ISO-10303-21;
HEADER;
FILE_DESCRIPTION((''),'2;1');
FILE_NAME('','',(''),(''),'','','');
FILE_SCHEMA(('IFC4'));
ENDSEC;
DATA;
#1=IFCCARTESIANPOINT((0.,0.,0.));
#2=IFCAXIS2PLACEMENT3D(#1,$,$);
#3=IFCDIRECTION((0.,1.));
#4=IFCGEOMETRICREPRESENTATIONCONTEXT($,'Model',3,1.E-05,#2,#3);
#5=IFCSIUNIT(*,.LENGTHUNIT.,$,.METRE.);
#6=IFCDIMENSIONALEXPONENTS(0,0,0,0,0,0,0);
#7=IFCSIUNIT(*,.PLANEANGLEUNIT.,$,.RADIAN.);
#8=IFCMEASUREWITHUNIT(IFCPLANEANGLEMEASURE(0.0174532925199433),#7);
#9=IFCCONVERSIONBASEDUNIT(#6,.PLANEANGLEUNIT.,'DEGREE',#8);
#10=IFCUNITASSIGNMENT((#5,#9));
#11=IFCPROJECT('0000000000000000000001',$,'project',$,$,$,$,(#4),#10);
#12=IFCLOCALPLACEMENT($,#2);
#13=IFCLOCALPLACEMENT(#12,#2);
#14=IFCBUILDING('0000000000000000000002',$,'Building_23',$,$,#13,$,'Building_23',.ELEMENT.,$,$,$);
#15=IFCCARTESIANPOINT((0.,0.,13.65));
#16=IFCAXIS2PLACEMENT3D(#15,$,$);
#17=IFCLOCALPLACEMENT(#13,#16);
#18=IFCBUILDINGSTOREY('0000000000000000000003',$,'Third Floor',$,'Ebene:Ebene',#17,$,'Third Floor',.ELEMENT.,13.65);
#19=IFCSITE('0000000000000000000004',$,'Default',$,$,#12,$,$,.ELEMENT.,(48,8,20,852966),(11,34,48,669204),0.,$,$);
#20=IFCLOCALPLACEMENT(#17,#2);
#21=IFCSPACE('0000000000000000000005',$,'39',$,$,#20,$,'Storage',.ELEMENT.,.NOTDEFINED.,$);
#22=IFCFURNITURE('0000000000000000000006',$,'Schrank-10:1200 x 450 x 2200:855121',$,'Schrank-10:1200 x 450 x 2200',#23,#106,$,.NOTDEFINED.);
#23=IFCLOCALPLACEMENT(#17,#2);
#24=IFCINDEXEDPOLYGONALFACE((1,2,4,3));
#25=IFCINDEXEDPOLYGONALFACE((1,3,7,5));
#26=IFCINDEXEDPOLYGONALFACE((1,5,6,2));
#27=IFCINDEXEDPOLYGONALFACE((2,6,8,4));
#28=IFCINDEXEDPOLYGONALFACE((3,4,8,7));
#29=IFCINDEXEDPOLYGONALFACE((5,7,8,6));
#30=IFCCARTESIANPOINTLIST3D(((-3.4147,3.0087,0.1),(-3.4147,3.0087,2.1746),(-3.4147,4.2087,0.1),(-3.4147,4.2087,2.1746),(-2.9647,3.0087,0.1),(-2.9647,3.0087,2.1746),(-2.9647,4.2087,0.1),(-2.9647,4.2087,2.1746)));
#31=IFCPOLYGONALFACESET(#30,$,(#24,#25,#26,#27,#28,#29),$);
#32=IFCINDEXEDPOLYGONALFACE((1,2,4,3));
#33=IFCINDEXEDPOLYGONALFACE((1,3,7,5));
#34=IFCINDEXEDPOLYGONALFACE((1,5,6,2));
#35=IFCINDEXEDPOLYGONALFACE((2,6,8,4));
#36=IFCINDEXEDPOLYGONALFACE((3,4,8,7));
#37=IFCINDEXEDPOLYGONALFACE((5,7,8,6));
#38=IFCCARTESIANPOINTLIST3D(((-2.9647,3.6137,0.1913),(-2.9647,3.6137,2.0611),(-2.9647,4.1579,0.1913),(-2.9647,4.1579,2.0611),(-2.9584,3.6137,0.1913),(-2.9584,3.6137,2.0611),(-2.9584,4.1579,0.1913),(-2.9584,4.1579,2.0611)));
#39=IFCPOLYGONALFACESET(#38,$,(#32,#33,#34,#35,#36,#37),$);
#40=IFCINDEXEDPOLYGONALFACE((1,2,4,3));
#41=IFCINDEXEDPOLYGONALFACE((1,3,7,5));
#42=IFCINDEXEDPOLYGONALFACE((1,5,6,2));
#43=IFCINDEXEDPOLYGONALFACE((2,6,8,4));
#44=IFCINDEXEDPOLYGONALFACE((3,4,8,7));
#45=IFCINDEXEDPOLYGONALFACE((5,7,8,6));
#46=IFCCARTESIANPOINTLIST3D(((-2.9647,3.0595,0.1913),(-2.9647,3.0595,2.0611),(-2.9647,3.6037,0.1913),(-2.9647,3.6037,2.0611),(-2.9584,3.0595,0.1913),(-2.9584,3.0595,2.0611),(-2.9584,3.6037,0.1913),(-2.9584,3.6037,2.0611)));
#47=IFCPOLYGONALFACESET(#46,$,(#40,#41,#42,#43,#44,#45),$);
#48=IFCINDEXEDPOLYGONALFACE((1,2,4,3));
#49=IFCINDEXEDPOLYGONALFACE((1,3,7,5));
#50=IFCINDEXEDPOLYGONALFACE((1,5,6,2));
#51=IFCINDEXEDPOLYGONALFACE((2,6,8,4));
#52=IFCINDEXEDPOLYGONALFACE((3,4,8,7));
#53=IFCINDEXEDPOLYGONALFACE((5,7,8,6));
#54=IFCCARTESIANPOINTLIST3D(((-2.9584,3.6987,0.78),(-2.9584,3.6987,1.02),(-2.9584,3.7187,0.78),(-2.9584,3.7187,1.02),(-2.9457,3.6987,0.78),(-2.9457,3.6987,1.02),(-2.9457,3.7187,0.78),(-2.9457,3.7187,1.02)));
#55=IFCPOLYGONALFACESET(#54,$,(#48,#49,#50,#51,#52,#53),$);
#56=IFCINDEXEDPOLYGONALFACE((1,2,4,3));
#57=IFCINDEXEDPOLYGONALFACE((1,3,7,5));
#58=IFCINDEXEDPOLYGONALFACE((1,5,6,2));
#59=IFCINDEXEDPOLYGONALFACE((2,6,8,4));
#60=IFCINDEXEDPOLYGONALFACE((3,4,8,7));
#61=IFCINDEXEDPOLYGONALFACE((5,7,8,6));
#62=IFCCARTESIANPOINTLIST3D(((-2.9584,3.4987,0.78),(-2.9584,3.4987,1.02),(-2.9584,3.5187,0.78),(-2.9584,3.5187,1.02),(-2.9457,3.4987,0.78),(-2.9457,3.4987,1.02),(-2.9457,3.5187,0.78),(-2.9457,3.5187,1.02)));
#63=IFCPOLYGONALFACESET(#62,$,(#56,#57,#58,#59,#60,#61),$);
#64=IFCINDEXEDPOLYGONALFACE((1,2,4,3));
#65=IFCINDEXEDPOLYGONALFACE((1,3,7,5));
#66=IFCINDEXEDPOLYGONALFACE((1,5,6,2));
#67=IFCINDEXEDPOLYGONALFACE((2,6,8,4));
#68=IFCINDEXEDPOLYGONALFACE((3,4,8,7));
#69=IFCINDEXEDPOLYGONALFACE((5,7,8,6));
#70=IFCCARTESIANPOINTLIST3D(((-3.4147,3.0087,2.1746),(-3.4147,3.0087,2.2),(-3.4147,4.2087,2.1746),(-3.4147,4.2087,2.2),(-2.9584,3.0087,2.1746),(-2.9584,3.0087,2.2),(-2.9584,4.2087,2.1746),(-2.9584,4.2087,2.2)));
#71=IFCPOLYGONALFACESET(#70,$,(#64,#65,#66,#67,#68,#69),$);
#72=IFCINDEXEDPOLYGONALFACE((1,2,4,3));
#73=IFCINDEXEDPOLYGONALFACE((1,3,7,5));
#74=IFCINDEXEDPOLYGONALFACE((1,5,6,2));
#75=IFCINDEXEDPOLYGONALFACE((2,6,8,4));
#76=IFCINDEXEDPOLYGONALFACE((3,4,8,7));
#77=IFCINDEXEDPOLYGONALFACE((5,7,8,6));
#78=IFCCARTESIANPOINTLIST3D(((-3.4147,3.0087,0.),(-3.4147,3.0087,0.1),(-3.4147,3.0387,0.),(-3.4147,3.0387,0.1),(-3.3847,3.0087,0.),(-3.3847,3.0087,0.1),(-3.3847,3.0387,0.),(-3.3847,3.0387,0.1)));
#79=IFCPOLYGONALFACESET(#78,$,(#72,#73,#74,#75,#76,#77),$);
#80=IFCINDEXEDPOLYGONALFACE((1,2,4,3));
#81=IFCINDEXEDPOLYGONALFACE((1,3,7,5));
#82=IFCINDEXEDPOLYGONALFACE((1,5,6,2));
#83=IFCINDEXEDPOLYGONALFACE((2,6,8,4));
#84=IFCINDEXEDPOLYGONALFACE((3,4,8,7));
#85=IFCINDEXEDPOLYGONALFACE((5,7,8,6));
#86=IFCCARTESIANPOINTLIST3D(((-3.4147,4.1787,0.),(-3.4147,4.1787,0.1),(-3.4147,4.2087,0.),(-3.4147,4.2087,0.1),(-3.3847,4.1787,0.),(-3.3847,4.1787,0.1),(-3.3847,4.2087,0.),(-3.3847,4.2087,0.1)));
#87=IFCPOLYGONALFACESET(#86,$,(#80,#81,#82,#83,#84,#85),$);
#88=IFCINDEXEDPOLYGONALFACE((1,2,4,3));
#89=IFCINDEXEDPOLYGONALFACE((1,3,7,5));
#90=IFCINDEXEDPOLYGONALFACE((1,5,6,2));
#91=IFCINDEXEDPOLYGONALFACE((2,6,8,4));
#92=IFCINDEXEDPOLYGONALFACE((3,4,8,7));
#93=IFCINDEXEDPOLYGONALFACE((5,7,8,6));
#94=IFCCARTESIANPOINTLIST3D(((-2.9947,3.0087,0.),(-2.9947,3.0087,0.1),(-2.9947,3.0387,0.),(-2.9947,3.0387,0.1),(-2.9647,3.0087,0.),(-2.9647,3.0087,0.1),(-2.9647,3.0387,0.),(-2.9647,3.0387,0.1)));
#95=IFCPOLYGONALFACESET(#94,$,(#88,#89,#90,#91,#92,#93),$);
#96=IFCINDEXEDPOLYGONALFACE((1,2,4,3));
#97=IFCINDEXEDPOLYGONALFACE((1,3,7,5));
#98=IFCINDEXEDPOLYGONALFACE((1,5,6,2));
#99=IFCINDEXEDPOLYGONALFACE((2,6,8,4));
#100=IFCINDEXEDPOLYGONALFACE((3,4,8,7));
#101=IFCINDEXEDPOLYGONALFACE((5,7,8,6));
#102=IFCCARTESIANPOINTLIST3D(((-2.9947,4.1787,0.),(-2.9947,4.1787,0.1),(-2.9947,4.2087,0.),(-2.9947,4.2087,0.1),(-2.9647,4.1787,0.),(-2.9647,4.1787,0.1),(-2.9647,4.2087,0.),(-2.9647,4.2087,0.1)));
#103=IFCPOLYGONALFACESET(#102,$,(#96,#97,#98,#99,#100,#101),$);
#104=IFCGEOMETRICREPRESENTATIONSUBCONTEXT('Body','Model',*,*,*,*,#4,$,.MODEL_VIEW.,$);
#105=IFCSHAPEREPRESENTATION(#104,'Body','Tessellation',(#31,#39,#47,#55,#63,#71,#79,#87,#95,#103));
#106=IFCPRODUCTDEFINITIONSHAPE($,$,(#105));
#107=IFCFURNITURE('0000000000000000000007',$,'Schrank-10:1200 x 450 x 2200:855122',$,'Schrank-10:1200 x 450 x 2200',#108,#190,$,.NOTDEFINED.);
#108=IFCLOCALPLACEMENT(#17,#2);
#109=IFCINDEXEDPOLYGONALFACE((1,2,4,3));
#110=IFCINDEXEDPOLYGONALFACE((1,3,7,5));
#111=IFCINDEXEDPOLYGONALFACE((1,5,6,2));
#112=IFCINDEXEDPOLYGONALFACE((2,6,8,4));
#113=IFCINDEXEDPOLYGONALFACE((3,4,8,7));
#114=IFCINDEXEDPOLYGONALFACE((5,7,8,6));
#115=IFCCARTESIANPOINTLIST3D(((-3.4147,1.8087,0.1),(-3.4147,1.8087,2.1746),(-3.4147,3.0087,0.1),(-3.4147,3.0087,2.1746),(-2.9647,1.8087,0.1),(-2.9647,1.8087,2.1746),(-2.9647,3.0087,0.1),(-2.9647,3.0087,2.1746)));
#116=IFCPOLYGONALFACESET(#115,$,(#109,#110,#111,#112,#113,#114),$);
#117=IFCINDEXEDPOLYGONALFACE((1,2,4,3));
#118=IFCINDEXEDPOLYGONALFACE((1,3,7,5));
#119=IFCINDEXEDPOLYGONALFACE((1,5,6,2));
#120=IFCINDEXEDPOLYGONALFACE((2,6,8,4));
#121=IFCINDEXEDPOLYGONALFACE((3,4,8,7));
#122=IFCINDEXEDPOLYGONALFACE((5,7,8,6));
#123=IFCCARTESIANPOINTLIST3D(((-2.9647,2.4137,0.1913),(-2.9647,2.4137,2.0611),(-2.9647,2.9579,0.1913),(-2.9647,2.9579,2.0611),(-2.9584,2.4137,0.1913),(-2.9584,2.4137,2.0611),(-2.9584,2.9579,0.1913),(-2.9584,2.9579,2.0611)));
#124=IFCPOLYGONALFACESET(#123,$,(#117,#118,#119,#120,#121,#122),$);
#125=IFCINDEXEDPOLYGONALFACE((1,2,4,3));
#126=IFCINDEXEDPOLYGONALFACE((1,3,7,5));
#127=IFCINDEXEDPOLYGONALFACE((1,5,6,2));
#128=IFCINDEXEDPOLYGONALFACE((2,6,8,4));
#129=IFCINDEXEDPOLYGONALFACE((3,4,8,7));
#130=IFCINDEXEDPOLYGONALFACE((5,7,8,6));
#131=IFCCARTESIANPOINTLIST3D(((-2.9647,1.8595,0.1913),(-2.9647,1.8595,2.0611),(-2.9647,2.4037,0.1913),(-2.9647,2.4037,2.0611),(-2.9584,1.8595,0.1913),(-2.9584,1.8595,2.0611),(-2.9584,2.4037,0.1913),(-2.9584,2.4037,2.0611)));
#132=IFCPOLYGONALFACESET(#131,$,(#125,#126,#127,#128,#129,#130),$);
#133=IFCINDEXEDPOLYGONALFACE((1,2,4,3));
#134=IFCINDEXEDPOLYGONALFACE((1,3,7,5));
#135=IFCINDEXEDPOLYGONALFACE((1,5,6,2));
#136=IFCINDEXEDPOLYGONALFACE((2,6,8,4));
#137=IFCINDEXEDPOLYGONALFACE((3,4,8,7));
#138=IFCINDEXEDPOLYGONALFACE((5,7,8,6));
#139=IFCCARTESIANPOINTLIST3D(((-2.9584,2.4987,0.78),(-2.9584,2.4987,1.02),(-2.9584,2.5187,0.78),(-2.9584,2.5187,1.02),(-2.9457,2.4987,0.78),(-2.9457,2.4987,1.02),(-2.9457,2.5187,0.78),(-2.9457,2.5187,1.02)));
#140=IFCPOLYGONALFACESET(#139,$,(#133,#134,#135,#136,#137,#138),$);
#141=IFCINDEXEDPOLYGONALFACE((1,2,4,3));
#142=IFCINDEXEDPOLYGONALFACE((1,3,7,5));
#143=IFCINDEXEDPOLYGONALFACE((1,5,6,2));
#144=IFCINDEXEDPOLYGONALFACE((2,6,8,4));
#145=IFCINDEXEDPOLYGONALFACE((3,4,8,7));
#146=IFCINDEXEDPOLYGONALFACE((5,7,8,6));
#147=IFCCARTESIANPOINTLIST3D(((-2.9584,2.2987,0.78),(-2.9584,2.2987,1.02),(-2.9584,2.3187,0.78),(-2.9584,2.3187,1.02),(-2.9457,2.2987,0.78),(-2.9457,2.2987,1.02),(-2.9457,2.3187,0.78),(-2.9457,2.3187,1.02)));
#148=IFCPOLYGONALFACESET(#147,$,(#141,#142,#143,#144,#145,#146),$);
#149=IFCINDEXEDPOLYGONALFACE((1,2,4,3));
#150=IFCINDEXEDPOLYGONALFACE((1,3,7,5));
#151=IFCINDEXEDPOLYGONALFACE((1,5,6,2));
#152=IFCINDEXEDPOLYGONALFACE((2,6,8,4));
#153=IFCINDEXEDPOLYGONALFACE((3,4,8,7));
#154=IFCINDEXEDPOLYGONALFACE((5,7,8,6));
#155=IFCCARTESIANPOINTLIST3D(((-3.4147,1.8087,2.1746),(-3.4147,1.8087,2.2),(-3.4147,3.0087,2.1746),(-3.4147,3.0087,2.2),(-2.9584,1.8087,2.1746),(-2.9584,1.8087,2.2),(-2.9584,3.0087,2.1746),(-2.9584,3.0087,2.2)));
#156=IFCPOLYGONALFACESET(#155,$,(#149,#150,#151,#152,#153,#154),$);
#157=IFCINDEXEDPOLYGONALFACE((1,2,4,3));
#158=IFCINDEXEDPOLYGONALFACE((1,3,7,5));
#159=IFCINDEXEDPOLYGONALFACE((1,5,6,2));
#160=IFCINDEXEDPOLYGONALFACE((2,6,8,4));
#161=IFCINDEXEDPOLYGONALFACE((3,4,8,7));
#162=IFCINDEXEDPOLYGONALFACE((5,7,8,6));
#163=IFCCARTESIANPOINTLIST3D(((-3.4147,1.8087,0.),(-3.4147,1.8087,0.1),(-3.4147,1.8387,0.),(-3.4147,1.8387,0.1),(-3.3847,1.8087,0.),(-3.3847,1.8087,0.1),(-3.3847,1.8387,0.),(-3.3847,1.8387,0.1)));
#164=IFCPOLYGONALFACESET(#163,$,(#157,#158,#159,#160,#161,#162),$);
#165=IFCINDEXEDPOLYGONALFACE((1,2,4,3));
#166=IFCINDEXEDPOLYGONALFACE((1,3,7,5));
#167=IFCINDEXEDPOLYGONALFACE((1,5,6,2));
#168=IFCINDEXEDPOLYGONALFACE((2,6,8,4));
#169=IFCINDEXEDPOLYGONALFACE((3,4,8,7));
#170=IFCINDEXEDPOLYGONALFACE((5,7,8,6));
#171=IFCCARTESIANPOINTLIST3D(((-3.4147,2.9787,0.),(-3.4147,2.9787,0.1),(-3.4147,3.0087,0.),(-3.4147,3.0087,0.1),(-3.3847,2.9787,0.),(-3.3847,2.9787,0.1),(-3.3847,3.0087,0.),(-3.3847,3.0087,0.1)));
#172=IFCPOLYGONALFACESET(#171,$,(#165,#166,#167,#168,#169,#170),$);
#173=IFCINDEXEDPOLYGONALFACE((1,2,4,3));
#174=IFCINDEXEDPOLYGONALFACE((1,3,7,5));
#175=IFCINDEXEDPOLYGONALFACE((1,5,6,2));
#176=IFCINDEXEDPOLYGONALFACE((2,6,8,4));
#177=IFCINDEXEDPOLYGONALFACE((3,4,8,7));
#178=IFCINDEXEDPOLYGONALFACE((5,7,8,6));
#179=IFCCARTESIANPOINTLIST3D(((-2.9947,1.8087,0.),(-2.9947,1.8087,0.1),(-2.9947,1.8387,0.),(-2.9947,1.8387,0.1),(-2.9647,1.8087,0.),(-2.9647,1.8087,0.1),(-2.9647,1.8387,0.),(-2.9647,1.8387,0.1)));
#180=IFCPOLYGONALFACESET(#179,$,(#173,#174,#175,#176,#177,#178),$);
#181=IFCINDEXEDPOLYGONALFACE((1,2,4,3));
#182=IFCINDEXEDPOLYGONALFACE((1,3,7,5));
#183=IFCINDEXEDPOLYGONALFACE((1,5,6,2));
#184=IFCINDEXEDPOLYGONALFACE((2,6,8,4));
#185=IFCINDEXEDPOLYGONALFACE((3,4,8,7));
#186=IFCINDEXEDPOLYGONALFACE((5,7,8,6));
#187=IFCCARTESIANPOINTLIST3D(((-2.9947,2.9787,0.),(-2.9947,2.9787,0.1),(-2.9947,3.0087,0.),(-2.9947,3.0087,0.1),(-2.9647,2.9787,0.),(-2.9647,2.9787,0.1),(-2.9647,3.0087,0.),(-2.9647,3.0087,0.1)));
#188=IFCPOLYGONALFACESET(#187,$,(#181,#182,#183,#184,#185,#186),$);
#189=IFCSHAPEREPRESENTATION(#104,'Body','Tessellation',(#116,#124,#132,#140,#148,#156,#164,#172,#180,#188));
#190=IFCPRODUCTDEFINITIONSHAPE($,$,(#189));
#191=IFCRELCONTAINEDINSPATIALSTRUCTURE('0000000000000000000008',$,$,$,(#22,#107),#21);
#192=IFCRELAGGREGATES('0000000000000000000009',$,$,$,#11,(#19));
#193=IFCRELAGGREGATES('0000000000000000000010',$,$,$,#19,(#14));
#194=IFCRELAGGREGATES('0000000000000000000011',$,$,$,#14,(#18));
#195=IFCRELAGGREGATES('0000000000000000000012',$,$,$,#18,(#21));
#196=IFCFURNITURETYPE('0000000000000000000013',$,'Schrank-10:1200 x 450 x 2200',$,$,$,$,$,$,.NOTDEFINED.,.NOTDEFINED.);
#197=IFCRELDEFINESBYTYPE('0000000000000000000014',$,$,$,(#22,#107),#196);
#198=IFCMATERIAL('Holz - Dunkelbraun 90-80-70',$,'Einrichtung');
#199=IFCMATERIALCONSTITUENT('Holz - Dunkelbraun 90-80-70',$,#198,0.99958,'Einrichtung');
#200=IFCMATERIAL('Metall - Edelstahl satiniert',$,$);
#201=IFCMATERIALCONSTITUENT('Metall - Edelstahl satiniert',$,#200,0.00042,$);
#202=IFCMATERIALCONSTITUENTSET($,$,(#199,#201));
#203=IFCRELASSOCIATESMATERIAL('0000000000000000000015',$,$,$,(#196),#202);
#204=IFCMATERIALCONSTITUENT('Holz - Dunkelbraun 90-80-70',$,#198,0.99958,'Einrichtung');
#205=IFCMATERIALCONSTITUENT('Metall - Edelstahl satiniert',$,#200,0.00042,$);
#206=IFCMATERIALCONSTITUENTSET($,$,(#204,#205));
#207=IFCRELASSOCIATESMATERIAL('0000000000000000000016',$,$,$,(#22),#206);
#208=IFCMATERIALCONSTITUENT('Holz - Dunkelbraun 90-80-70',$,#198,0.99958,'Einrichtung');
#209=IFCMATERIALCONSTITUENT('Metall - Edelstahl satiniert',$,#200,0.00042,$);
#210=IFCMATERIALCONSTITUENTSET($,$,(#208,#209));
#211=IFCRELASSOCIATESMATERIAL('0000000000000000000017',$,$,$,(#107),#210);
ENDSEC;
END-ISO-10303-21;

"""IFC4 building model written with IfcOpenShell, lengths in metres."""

from ifc_helpers import new_model, entity, si_unit, converted_unit, direction, frame, origin, place, context, subcontext, project, spatial, indexed_curve, outline, extrude, source, transform, mapped, material, constituent, constituent_set, type_object, type_shapes, element, save


model = new_model("IFC4")

# Units and contexts
model_context = context("Model", 3, precision=1e-05, world=origin(), true_north=direction((0.0, 1.0)))
body_context = subcontext(model_context, "Body", "Model", "MODEL_VIEW")
ifc_project = project(units=[si_unit("LENGTHUNIT", "METRE"), converted_unit("PLANEANGLEUNIT", "DEGREE", entity("IfcPlaneAngleMeasure", 0.0174532925199433), si_unit("PLANEANGLEUNIT", "RADIAN"), dimensions=[0, 0, 0, 0, 0, 0, 0])], contexts=[model_context])

# Site, building, storey
site_placement = place(None, origin())
site = spatial("IfcSite", under=ifc_project, at=site_placement, Name="Default", CompositionType="ELEMENT", RefLatitude=(48, 8, 20, 852966), RefLongitude=(11, 34, 48, 669204), RefElevation=0.0)
building_placement = place(site_placement, origin())
building = spatial("IfcBuilding", under=site, at=building_placement, Name="Building_23", LongName="Building_23", CompositionType="ELEMENT")
storey_placement = place(building_placement, frame((0.0, 0.0, 13.65)))
storey = spatial("IfcBuildingStorey", under=building, at=storey_placement, Name="Third Floor", ObjectType="Ebene:Ebene", LongName="Third Floor", CompositionType="ELEMENT", Elevation=13.65)

# Shared definitions
ifc_material_1 = material(Name="Holz - Dunkelbraun 90-80-70", Category="Einrichtung")
ifc_material_2 = material(Name="Metall - Edelstahl satiniert")

# Shared definitions
space_1_placement = place(storey_placement, origin())
space_1 = spatial("IfcSpace", under=storey, at=space_1_placement, Name="39", LongName="Storage", CompositionType="ELEMENT", PredefinedType="NOTDEFINED")

# Furniture
ifc_constituent_1 = constituent(ifc_material_1, Name="Holz - Dunkelbraun 90-80-70", Category="Einrichtung", fraction=0.99958)
ifc_constituent_2 = constituent(ifc_material_2, Name="Metall - Edelstahl satiniert", fraction=0.00042)
ifc_constituent_set_1 = constituent_set(constituents=[ifc_constituent_1, ifc_constituent_2])
ifc_constituent_3 = constituent(ifc_material_1, Name="Holz - Dunkelbraun 90-80-70", Category="Einrichtung", fraction=0.99958)
ifc_constituent_4 = constituent(ifc_material_2, Name="Metall - Edelstahl satiniert", fraction=0.00042)
ifc_constituent_set_2 = constituent_set(constituents=[ifc_constituent_3, ifc_constituent_4])
furniture_type_1 = type_object("IfcFurnitureType", Name="Schrank-10:1200 x 450 x 2200", AssemblyPlace="NOTDEFINED", PredefinedType="NOTDEFINED", material=ifc_constituent_set_2)
shared_shape_1 = source(origin(), body_context, "Body", "SweptSolid", [
    extrude(outline(indexed_curve([(-0.225, -0.6), (0.225, -0.6), (0.225, 0.6), (-0.225, 0.6), (-0.225, -0.6)], self_intersect=False)), frame((-0.2692, -0.3632, 0.1), z_axis=(0.0, 0.0, 1.0), x_axis=(0.0, 1.0, 0.0)), (0.0, 0.0, 1.0), 2.0746),
    extrude(outline(indexed_curve([(-0.0032, -0.2721), (0.0032, -0.2721), (0.0032, 0.2721), (-0.0032, 0.2721), (-0.0032, -0.2721)], self_intersect=False)), frame((0.0079, -0.5913, 0.1913), z_axis=(0.0, 0.0, 1.0), x_axis=(0.0, 1.0, 0.0)), (0.0, 0.0, 1.0), 1.8698),
    extrude(outline(indexed_curve([(-0.0032, -0.2721), (0.0032, -0.2721), (0.0032, 0.2721), (-0.0032, 0.2721), (-0.0032, -0.2721)], self_intersect=False)), frame((-0.5463, -0.5913, 0.1913), z_axis=(0.0, 0.0, 1.0), x_axis=(0.0, 1.0, 0.0)), (0.0, 0.0, 1.0), 1.8698),
    extrude(outline(indexed_curve([(-0.0063, -0.01), (0.0063, -0.01), (0.0063, 0.01), (-0.0063, 0.01), (-0.0063, -0.01)], self_intersect=False)), frame((-0.1692, -0.6009, 0.78), z_axis=(0.0, 0.0, 1.0), x_axis=(0.0, 1.0, 0.0)), (0.0, 0.0, 1.0), 0.24),
    extrude(outline(indexed_curve([(-0.0063, -0.01), (0.0063, -0.01), (0.0063, 0.01), (-0.0063, 0.01), (-0.0063, -0.01)], self_intersect=False)), frame((-0.3692, -0.6009, 0.78), z_axis=(0.0, 0.0, 1.0), x_axis=(0.0, 1.0, 0.0)), (0.0, 0.0, 1.0), 0.24),
    extrude(outline(indexed_curve([(-0.6, -0.2282), (0.6, -0.2282), (0.6, 0.2282), (-0.6, 0.2282), (-0.6, -0.2282)], self_intersect=False)), frame((-0.2692, -0.3663, 2.1746), z_axis=(0.0, 0.0, 1.0), x_axis=(-1.0, 0.0, 0.0)), (0.0, 0.0, 1.0), 0.0254),
    extrude(outline(indexed_curve([(-0.015, -0.015), (0.015, -0.015), (0.015, 0.015), (-0.015, 0.015), (-0.015, -0.015)], self_intersect=False)), frame((-0.8542, -0.1532, 0.0), z_axis=(0.0, 0.0, 1.0), x_axis=(-1.0, 0.0, 0.0)), (0.0, 0.0, 1.0), 0.1),
    extrude(outline(indexed_curve([(-0.015, -0.015), (0.015, -0.015), (0.015, 0.015), (-0.015, 0.015), (-0.015, -0.015)], self_intersect=False)), frame((0.3158, -0.1532, 0.0), z_axis=(0.0, 0.0, 1.0), x_axis=(0.0, -1.0, 0.0)), (0.0, 0.0, 1.0), 0.1),
    extrude(outline(indexed_curve([(-0.015, -0.015), (0.015, -0.015), (0.015, 0.015), (-0.015, 0.015), (-0.015, -0.015)], self_intersect=False)), frame((-0.8542, -0.5732, 0.0), z_axis=(0.0, 0.0, 1.0), x_axis=(0.0, 1.0, 0.0)), (0.0, 0.0, 1.0), 0.1),
    extrude(outline(indexed_curve([(-0.015, -0.015), (0.015, -0.015), (0.015, 0.015), (-0.015, 0.015), (-0.015, -0.015)], self_intersect=False)), frame((0.3158, -0.5732, 0.0)), (0.0, 0.0, 1.0), 0.1),
])
type_shapes(furniture_type_1, [shared_shape_1])
furniture_1_placement = place(space_1_placement, frame((-3.5529, 3.8779, 0.0), z_axis=(0.0, 0.0, 1.0), x_axis=(0.0, 1.0, 0.0)))
element("IfcFurniture", 1, at=furniture_1_placement, inside=space_1, type_object=furniture_type_1, material=ifc_constituent_set_1, Name="Schrank-10:1200 x 450 x 2200:855121", ObjectType="Schrank-10:1200 x 450 x 2200", PredefinedType="NOTDEFINED", context=body_context, shape_type="MappedRepresentation", body=[
    mapped(shared_shape_1, transform((0.0, 0.0, 0.0), scale=1.0)),
])
ifc_constituent_5 = constituent(ifc_material_1, Name="Holz - Dunkelbraun 90-80-70", Category="Einrichtung", fraction=0.99958)
ifc_constituent_6 = constituent(ifc_material_2, Name="Metall - Edelstahl satiniert", fraction=0.00042)
ifc_constituent_set_3 = constituent_set(constituents=[ifc_constituent_5, ifc_constituent_6])
furniture_2_placement = place(space_1_placement, frame((-3.5529, 2.6779, 0.0), z_axis=(0.0, 0.0, 1.0), x_axis=(0.0, 1.0, 0.0)))
element("IfcFurniture", 2, at=furniture_2_placement, inside=space_1, type_object=furniture_type_1, material=ifc_constituent_set_3, Name="Schrank-10:1200 x 450 x 2200:855122", ObjectType="Schrank-10:1200 x 450 x 2200", PredefinedType="NOTDEFINED", context=body_context, shape_type="MappedRepresentation", body=[
    mapped(shared_shape_1, transform((0.0, 0.0, 0.0), scale=1.0)),
])

save(model, "model.ifc")
